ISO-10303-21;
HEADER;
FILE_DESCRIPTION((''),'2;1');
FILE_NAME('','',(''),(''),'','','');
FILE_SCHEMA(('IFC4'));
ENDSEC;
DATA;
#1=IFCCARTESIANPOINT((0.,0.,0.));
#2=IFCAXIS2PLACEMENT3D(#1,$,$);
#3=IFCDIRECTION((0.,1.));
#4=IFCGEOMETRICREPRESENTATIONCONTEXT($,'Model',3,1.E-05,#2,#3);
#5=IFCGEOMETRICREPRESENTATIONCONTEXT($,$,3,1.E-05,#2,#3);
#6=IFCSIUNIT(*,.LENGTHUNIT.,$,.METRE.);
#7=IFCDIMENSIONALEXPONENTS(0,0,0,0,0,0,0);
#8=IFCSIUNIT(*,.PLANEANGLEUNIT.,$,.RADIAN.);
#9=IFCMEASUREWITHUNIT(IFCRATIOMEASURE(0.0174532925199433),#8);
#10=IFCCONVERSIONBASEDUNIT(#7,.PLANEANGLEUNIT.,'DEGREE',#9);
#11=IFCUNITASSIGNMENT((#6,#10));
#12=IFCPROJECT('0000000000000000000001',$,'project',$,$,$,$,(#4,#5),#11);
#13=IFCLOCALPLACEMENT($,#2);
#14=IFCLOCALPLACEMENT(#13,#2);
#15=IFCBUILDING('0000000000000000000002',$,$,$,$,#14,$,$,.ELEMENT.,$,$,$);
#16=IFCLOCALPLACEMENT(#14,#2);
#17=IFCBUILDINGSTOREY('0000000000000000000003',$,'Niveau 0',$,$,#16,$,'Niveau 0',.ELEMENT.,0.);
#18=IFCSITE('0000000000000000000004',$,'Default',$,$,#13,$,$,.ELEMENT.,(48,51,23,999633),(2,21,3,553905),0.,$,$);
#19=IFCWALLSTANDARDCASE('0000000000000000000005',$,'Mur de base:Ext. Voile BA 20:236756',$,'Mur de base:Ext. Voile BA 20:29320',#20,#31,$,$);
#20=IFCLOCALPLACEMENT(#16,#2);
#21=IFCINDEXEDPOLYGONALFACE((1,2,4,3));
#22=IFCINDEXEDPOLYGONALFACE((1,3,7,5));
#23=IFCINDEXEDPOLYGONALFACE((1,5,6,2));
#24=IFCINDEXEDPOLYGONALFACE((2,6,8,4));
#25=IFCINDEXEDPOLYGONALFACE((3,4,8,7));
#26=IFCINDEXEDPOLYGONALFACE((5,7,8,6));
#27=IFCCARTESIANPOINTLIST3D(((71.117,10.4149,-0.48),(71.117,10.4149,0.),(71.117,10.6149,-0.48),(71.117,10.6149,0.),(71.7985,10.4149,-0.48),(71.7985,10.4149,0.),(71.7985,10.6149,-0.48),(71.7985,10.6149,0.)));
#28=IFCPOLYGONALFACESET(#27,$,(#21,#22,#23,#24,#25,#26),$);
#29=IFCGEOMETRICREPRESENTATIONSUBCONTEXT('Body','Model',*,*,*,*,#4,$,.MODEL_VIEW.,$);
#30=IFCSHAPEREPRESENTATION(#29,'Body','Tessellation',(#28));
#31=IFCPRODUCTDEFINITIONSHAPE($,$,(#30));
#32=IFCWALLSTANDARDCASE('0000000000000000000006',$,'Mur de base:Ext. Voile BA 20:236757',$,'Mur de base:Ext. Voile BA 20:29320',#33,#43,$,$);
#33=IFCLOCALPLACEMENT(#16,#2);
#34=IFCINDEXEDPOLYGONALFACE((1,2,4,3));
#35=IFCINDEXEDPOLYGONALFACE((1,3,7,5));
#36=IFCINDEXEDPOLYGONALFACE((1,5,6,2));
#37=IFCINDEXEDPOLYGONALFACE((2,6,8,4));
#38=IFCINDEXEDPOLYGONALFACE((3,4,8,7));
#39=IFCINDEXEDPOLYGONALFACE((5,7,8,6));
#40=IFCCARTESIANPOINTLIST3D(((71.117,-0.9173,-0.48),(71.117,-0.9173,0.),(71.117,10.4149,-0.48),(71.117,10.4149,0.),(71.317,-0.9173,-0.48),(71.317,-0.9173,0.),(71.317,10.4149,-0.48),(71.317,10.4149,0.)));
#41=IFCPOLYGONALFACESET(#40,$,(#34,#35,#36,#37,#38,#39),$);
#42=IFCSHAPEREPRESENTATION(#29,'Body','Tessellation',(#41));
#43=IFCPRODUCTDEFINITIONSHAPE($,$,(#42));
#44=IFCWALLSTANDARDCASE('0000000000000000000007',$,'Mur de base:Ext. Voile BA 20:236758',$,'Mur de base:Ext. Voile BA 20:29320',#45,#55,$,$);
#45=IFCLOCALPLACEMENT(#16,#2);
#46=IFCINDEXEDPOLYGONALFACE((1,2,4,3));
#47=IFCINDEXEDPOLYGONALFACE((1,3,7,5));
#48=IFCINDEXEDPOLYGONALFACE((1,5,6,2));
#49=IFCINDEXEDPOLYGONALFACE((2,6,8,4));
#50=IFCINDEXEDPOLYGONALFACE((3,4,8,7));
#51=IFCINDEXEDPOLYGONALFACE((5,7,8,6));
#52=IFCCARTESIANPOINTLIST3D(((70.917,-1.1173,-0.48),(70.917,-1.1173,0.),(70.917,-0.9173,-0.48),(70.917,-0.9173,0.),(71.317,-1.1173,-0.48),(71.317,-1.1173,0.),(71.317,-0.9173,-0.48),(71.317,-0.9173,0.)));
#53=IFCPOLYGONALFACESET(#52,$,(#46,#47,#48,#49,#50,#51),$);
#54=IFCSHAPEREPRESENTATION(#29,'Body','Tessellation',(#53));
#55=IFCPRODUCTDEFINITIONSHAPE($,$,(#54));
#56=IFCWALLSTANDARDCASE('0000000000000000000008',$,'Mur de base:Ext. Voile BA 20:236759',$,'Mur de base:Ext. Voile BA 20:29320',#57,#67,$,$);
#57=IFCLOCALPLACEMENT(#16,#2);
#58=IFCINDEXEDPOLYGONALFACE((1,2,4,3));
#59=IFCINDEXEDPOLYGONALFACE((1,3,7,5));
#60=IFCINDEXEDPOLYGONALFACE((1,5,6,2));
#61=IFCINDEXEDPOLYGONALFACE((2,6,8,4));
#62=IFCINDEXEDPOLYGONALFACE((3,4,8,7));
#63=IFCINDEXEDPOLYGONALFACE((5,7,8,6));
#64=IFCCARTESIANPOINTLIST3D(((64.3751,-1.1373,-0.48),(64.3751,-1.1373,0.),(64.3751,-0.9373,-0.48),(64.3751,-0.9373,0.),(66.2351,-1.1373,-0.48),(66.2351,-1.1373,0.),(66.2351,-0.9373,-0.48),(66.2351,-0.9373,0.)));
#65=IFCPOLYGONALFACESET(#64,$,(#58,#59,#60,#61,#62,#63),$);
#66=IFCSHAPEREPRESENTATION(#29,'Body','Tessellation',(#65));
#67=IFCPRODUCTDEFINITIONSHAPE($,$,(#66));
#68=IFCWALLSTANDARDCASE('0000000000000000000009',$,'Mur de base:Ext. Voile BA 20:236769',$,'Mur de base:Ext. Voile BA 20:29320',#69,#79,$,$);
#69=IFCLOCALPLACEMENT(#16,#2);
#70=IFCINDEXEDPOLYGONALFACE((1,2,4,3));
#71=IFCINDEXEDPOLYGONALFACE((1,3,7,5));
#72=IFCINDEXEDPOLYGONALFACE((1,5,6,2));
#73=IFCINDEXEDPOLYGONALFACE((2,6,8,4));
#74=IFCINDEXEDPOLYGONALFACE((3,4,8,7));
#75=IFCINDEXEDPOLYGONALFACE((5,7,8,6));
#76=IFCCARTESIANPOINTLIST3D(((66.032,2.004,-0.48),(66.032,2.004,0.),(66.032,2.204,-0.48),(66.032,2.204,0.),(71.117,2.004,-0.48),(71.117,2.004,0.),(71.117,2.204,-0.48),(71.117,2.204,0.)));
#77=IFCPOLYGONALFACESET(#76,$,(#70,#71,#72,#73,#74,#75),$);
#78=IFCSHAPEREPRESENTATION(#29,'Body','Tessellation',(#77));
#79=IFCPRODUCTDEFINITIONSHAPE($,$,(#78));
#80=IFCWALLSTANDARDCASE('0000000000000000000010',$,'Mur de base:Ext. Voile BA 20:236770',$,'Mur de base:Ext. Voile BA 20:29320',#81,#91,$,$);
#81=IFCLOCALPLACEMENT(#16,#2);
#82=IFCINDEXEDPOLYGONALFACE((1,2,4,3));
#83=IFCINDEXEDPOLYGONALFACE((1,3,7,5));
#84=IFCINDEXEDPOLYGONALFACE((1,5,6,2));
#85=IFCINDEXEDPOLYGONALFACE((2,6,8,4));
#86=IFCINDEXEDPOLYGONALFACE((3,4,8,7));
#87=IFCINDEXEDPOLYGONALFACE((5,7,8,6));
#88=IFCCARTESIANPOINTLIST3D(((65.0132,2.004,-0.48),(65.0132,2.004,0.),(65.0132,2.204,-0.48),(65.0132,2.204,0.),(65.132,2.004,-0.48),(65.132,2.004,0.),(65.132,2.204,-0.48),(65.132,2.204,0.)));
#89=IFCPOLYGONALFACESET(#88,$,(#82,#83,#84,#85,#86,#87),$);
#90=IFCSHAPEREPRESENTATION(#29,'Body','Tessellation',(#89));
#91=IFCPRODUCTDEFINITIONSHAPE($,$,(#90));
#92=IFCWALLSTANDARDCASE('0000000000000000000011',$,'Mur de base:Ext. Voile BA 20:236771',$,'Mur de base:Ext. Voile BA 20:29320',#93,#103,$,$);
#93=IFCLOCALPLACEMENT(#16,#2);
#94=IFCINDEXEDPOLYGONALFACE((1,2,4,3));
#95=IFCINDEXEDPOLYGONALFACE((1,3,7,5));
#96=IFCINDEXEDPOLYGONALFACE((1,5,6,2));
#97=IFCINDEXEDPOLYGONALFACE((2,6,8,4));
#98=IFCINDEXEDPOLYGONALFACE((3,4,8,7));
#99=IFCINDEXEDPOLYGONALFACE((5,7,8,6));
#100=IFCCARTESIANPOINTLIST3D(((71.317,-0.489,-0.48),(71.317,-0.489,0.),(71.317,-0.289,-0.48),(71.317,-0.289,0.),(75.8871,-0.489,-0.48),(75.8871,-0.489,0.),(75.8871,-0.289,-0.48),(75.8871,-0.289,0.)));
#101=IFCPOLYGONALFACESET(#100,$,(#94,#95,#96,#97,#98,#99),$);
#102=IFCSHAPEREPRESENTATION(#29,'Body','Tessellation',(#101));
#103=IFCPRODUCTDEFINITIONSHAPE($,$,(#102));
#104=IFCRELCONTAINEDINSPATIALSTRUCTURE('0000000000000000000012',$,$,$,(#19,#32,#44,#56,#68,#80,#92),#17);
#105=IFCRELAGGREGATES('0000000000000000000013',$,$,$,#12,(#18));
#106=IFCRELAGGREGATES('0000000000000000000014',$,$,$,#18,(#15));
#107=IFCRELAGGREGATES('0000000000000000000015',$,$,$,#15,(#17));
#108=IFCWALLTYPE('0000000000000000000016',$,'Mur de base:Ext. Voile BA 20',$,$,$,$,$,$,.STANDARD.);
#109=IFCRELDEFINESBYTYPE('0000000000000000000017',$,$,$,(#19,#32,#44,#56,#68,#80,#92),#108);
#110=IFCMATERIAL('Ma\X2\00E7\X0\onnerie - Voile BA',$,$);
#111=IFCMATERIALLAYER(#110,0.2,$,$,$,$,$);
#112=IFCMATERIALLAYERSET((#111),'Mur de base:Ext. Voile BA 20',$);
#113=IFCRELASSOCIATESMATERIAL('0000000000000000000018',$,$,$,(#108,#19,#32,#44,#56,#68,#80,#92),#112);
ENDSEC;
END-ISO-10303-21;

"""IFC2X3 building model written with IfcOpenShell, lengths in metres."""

from ifc_helpers import new_model, entity, si_unit, converted_unit, direction, frame, frame_2d, origin, place, context, subcontext, project, spatial, rectangle, extrude, material, layer, layer_set, layer_usage, type_object, element, save


model = new_model("IFC2X3")

# Units and contexts
model_context = context("Model", 3, precision=1e-05, world=origin(), true_north=direction((0.0, 1.0)))
context_of_model = context(None, 3, precision=1e-05, world=origin(), true_north=direction((0.0, 1.0)))
body_context = subcontext(model_context, "Body", "Model", "MODEL_VIEW")
ifc_project = project(units=[si_unit("LENGTHUNIT", "METRE"), converted_unit("PLANEANGLEUNIT", "DEGREE", entity("IfcRatioMeasure", 0.0174532925199433), si_unit("PLANEANGLEUNIT", "RADIAN"), dimensions=[0, 0, 0, 0, 0, 0, 0])], contexts=[model_context, context_of_model])

# Site, building, storey
site_placement = place(None, origin())
site = spatial("IfcSite", under=ifc_project, at=site_placement, Name="Default", CompositionType="ELEMENT", RefLatitude=(48, 51, 23, 999633), RefLongitude=(2, 21, 3, 553905), RefElevation=0.0)
building_placement = place(site_placement, origin())
building = spatial("IfcBuilding", under=site, at=building_placement, CompositionType="ELEMENT")
storey_placement = place(building_placement, origin())
storey = spatial("IfcBuildingStorey", under=building, at=storey_placement, Name="Niveau 0", LongName="Niveau 0", CompositionType="ELEMENT", Elevation=0.0)

# Shared definitions
ifc_material = material(Name="Maçonnerie - Voile BA")
ifc_layer = layer(ifc_material, 0.2)
ifc_layer_set = layer_set([ifc_layer], Name="Mur de base:Ext. Voile BA 20")
wall_type = type_object("IfcWallType", Name="Mur de base:Ext. Voile BA 20", PredefinedType="STANDARD", material=ifc_layer_set)

# Walls
ifc_layer_usage_1 = layer_usage(ifc_layer_set, "AXIS2", "NEGATIVE", 0.1)
wall_1_placement = place(storey_placement, frame((71.7985, 10.5149, -0.48), z_axis=(0.0, 0.0, 1.0), x_axis=(-1.0, 0.0, 0.0)))
element("IfcWallStandardCase", 1, at=wall_1_placement, inside=storey, type_object=wall_type, material=ifc_layer_usage_1, Name="Mur de base:Ext. Voile BA 20:236756", ObjectType="Mur de base:Ext. Voile BA 20:29320", context=body_context, shape_type="SweptSolid", body=[
    extrude(rectangle(XDim=0.6815, YDim=0.2, at=frame_2d((0.3407, 0.0), x_axis=(-1.0, 0.0))), origin(), (0.0, 0.0, 1.0), 0.48),
])
ifc_layer_usage_2 = layer_usage(ifc_layer_set, "AXIS2", "NEGATIVE", 0.1)
wall_2_placement = place(storey_placement, frame((71.217, 10.4149, -0.48), z_axis=(0.0, 0.0, 1.0), x_axis=(0.0, -1.0, 0.0)))
element("IfcWallStandardCase", 2, at=wall_2_placement, inside=storey, type_object=wall_type, material=ifc_layer_usage_2, Name="Mur de base:Ext. Voile BA 20:236757", ObjectType="Mur de base:Ext. Voile BA 20:29320", context=body_context, shape_type="SweptSolid", body=[
    extrude(rectangle(XDim=11.3322, YDim=0.2, at=frame_2d((5.6661, 0.0), x_axis=(-1.0, 0.0))), origin(), (0.0, 0.0, 1.0), 0.48),
])
ifc_layer_usage_3 = layer_usage(ifc_layer_set, "AXIS2", "NEGATIVE", 0.1)
wall_3_placement = place(storey_placement, frame((71.317, -1.0173, -0.48), z_axis=(0.0, 0.0, 1.0), x_axis=(-1.0, 0.0, 0.0)))
element("IfcWallStandardCase", 3, at=wall_3_placement, inside=storey, type_object=wall_type, material=ifc_layer_usage_3, Name="Mur de base:Ext. Voile BA 20:236758", ObjectType="Mur de base:Ext. Voile BA 20:29320", context=body_context, shape_type="SweptSolid", body=[
    extrude(rectangle(XDim=0.4, YDim=0.2, at=frame_2d((0.2, 0.0), x_axis=(-1.0, 0.0))), origin(), (0.0, 0.0, 1.0), 0.48),
])
ifc_layer_usage_4 = layer_usage(ifc_layer_set, "AXIS2", "NEGATIVE", 0.1)
wall_4_placement = place(storey_placement, frame((66.2351, -1.0373, -0.48), z_axis=(0.0, 0.0, 1.0), x_axis=(-1.0, 0.0, 0.0)))
element("IfcWallStandardCase", 4, at=wall_4_placement, inside=storey, type_object=wall_type, material=ifc_layer_usage_4, Name="Mur de base:Ext. Voile BA 20:236759", ObjectType="Mur de base:Ext. Voile BA 20:29320", context=body_context, shape_type="SweptSolid", body=[
    extrude(rectangle(XDim=1.86, YDim=0.2, at=frame_2d((0.93, 0.0), x_axis=(-1.0, 0.0))), origin(), (0.0, 0.0, 1.0), 0.48),
])
ifc_layer_usage_5 = layer_usage(ifc_layer_set, "AXIS2", "NEGATIVE", 0.1)
wall_5_placement = place(storey_placement, frame((71.117, 2.104, -0.48), z_axis=(0.0, 0.0, 1.0), x_axis=(-1.0, 0.0, 0.0)))
element("IfcWallStandardCase", 5, at=wall_5_placement, inside=storey, type_object=wall_type, material=ifc_layer_usage_5, Name="Mur de base:Ext. Voile BA 20:236769", ObjectType="Mur de base:Ext. Voile BA 20:29320", context=body_context, shape_type="SweptSolid", body=[
    extrude(rectangle(XDim=5.085, YDim=0.2, at=frame_2d((2.5425, 0.0), x_axis=(-1.0, 0.0))), origin(), (0.0, 0.0, 1.0), 0.48),
])
ifc_layer_usage_6 = layer_usage(ifc_layer_set, "AXIS2", "NEGATIVE", 0.1)
wall_6_placement = place(storey_placement, frame((65.132, 2.104, -0.48), z_axis=(0.0, 0.0, 1.0), x_axis=(-1.0, 0.0, 0.0)))
element("IfcWallStandardCase", 6, at=wall_6_placement, inside=storey, type_object=wall_type, material=ifc_layer_usage_6, Name="Mur de base:Ext. Voile BA 20:236770", ObjectType="Mur de base:Ext. Voile BA 20:29320", context=body_context, shape_type="SweptSolid", body=[
    extrude(rectangle(XDim=0.1188, YDim=0.2, at=frame_2d((0.0594, 0.0), x_axis=(-1.0, 0.0))), origin(), (0.0, 0.0, 1.0), 0.48),
])
ifc_layer_usage_7 = layer_usage(ifc_layer_set, "AXIS2", "NEGATIVE", 0.1)
wall_7_placement = place(storey_placement, frame((71.317, -0.389, -0.48)))
element("IfcWallStandardCase", 7, at=wall_7_placement, inside=storey, type_object=wall_type, material=ifc_layer_usage_7, Name="Mur de base:Ext. Voile BA 20:236771", ObjectType="Mur de base:Ext. Voile BA 20:29320", context=body_context, shape_type="SweptSolid", body=[
    extrude(rectangle(XDim=4.5701, YDim=0.2, at=frame_2d((2.2851, 0.0), x_axis=(-1.0, 0.0))), origin(), (0.0, 0.0, 1.0), 0.48),
])

save(model, "model.ifc")
